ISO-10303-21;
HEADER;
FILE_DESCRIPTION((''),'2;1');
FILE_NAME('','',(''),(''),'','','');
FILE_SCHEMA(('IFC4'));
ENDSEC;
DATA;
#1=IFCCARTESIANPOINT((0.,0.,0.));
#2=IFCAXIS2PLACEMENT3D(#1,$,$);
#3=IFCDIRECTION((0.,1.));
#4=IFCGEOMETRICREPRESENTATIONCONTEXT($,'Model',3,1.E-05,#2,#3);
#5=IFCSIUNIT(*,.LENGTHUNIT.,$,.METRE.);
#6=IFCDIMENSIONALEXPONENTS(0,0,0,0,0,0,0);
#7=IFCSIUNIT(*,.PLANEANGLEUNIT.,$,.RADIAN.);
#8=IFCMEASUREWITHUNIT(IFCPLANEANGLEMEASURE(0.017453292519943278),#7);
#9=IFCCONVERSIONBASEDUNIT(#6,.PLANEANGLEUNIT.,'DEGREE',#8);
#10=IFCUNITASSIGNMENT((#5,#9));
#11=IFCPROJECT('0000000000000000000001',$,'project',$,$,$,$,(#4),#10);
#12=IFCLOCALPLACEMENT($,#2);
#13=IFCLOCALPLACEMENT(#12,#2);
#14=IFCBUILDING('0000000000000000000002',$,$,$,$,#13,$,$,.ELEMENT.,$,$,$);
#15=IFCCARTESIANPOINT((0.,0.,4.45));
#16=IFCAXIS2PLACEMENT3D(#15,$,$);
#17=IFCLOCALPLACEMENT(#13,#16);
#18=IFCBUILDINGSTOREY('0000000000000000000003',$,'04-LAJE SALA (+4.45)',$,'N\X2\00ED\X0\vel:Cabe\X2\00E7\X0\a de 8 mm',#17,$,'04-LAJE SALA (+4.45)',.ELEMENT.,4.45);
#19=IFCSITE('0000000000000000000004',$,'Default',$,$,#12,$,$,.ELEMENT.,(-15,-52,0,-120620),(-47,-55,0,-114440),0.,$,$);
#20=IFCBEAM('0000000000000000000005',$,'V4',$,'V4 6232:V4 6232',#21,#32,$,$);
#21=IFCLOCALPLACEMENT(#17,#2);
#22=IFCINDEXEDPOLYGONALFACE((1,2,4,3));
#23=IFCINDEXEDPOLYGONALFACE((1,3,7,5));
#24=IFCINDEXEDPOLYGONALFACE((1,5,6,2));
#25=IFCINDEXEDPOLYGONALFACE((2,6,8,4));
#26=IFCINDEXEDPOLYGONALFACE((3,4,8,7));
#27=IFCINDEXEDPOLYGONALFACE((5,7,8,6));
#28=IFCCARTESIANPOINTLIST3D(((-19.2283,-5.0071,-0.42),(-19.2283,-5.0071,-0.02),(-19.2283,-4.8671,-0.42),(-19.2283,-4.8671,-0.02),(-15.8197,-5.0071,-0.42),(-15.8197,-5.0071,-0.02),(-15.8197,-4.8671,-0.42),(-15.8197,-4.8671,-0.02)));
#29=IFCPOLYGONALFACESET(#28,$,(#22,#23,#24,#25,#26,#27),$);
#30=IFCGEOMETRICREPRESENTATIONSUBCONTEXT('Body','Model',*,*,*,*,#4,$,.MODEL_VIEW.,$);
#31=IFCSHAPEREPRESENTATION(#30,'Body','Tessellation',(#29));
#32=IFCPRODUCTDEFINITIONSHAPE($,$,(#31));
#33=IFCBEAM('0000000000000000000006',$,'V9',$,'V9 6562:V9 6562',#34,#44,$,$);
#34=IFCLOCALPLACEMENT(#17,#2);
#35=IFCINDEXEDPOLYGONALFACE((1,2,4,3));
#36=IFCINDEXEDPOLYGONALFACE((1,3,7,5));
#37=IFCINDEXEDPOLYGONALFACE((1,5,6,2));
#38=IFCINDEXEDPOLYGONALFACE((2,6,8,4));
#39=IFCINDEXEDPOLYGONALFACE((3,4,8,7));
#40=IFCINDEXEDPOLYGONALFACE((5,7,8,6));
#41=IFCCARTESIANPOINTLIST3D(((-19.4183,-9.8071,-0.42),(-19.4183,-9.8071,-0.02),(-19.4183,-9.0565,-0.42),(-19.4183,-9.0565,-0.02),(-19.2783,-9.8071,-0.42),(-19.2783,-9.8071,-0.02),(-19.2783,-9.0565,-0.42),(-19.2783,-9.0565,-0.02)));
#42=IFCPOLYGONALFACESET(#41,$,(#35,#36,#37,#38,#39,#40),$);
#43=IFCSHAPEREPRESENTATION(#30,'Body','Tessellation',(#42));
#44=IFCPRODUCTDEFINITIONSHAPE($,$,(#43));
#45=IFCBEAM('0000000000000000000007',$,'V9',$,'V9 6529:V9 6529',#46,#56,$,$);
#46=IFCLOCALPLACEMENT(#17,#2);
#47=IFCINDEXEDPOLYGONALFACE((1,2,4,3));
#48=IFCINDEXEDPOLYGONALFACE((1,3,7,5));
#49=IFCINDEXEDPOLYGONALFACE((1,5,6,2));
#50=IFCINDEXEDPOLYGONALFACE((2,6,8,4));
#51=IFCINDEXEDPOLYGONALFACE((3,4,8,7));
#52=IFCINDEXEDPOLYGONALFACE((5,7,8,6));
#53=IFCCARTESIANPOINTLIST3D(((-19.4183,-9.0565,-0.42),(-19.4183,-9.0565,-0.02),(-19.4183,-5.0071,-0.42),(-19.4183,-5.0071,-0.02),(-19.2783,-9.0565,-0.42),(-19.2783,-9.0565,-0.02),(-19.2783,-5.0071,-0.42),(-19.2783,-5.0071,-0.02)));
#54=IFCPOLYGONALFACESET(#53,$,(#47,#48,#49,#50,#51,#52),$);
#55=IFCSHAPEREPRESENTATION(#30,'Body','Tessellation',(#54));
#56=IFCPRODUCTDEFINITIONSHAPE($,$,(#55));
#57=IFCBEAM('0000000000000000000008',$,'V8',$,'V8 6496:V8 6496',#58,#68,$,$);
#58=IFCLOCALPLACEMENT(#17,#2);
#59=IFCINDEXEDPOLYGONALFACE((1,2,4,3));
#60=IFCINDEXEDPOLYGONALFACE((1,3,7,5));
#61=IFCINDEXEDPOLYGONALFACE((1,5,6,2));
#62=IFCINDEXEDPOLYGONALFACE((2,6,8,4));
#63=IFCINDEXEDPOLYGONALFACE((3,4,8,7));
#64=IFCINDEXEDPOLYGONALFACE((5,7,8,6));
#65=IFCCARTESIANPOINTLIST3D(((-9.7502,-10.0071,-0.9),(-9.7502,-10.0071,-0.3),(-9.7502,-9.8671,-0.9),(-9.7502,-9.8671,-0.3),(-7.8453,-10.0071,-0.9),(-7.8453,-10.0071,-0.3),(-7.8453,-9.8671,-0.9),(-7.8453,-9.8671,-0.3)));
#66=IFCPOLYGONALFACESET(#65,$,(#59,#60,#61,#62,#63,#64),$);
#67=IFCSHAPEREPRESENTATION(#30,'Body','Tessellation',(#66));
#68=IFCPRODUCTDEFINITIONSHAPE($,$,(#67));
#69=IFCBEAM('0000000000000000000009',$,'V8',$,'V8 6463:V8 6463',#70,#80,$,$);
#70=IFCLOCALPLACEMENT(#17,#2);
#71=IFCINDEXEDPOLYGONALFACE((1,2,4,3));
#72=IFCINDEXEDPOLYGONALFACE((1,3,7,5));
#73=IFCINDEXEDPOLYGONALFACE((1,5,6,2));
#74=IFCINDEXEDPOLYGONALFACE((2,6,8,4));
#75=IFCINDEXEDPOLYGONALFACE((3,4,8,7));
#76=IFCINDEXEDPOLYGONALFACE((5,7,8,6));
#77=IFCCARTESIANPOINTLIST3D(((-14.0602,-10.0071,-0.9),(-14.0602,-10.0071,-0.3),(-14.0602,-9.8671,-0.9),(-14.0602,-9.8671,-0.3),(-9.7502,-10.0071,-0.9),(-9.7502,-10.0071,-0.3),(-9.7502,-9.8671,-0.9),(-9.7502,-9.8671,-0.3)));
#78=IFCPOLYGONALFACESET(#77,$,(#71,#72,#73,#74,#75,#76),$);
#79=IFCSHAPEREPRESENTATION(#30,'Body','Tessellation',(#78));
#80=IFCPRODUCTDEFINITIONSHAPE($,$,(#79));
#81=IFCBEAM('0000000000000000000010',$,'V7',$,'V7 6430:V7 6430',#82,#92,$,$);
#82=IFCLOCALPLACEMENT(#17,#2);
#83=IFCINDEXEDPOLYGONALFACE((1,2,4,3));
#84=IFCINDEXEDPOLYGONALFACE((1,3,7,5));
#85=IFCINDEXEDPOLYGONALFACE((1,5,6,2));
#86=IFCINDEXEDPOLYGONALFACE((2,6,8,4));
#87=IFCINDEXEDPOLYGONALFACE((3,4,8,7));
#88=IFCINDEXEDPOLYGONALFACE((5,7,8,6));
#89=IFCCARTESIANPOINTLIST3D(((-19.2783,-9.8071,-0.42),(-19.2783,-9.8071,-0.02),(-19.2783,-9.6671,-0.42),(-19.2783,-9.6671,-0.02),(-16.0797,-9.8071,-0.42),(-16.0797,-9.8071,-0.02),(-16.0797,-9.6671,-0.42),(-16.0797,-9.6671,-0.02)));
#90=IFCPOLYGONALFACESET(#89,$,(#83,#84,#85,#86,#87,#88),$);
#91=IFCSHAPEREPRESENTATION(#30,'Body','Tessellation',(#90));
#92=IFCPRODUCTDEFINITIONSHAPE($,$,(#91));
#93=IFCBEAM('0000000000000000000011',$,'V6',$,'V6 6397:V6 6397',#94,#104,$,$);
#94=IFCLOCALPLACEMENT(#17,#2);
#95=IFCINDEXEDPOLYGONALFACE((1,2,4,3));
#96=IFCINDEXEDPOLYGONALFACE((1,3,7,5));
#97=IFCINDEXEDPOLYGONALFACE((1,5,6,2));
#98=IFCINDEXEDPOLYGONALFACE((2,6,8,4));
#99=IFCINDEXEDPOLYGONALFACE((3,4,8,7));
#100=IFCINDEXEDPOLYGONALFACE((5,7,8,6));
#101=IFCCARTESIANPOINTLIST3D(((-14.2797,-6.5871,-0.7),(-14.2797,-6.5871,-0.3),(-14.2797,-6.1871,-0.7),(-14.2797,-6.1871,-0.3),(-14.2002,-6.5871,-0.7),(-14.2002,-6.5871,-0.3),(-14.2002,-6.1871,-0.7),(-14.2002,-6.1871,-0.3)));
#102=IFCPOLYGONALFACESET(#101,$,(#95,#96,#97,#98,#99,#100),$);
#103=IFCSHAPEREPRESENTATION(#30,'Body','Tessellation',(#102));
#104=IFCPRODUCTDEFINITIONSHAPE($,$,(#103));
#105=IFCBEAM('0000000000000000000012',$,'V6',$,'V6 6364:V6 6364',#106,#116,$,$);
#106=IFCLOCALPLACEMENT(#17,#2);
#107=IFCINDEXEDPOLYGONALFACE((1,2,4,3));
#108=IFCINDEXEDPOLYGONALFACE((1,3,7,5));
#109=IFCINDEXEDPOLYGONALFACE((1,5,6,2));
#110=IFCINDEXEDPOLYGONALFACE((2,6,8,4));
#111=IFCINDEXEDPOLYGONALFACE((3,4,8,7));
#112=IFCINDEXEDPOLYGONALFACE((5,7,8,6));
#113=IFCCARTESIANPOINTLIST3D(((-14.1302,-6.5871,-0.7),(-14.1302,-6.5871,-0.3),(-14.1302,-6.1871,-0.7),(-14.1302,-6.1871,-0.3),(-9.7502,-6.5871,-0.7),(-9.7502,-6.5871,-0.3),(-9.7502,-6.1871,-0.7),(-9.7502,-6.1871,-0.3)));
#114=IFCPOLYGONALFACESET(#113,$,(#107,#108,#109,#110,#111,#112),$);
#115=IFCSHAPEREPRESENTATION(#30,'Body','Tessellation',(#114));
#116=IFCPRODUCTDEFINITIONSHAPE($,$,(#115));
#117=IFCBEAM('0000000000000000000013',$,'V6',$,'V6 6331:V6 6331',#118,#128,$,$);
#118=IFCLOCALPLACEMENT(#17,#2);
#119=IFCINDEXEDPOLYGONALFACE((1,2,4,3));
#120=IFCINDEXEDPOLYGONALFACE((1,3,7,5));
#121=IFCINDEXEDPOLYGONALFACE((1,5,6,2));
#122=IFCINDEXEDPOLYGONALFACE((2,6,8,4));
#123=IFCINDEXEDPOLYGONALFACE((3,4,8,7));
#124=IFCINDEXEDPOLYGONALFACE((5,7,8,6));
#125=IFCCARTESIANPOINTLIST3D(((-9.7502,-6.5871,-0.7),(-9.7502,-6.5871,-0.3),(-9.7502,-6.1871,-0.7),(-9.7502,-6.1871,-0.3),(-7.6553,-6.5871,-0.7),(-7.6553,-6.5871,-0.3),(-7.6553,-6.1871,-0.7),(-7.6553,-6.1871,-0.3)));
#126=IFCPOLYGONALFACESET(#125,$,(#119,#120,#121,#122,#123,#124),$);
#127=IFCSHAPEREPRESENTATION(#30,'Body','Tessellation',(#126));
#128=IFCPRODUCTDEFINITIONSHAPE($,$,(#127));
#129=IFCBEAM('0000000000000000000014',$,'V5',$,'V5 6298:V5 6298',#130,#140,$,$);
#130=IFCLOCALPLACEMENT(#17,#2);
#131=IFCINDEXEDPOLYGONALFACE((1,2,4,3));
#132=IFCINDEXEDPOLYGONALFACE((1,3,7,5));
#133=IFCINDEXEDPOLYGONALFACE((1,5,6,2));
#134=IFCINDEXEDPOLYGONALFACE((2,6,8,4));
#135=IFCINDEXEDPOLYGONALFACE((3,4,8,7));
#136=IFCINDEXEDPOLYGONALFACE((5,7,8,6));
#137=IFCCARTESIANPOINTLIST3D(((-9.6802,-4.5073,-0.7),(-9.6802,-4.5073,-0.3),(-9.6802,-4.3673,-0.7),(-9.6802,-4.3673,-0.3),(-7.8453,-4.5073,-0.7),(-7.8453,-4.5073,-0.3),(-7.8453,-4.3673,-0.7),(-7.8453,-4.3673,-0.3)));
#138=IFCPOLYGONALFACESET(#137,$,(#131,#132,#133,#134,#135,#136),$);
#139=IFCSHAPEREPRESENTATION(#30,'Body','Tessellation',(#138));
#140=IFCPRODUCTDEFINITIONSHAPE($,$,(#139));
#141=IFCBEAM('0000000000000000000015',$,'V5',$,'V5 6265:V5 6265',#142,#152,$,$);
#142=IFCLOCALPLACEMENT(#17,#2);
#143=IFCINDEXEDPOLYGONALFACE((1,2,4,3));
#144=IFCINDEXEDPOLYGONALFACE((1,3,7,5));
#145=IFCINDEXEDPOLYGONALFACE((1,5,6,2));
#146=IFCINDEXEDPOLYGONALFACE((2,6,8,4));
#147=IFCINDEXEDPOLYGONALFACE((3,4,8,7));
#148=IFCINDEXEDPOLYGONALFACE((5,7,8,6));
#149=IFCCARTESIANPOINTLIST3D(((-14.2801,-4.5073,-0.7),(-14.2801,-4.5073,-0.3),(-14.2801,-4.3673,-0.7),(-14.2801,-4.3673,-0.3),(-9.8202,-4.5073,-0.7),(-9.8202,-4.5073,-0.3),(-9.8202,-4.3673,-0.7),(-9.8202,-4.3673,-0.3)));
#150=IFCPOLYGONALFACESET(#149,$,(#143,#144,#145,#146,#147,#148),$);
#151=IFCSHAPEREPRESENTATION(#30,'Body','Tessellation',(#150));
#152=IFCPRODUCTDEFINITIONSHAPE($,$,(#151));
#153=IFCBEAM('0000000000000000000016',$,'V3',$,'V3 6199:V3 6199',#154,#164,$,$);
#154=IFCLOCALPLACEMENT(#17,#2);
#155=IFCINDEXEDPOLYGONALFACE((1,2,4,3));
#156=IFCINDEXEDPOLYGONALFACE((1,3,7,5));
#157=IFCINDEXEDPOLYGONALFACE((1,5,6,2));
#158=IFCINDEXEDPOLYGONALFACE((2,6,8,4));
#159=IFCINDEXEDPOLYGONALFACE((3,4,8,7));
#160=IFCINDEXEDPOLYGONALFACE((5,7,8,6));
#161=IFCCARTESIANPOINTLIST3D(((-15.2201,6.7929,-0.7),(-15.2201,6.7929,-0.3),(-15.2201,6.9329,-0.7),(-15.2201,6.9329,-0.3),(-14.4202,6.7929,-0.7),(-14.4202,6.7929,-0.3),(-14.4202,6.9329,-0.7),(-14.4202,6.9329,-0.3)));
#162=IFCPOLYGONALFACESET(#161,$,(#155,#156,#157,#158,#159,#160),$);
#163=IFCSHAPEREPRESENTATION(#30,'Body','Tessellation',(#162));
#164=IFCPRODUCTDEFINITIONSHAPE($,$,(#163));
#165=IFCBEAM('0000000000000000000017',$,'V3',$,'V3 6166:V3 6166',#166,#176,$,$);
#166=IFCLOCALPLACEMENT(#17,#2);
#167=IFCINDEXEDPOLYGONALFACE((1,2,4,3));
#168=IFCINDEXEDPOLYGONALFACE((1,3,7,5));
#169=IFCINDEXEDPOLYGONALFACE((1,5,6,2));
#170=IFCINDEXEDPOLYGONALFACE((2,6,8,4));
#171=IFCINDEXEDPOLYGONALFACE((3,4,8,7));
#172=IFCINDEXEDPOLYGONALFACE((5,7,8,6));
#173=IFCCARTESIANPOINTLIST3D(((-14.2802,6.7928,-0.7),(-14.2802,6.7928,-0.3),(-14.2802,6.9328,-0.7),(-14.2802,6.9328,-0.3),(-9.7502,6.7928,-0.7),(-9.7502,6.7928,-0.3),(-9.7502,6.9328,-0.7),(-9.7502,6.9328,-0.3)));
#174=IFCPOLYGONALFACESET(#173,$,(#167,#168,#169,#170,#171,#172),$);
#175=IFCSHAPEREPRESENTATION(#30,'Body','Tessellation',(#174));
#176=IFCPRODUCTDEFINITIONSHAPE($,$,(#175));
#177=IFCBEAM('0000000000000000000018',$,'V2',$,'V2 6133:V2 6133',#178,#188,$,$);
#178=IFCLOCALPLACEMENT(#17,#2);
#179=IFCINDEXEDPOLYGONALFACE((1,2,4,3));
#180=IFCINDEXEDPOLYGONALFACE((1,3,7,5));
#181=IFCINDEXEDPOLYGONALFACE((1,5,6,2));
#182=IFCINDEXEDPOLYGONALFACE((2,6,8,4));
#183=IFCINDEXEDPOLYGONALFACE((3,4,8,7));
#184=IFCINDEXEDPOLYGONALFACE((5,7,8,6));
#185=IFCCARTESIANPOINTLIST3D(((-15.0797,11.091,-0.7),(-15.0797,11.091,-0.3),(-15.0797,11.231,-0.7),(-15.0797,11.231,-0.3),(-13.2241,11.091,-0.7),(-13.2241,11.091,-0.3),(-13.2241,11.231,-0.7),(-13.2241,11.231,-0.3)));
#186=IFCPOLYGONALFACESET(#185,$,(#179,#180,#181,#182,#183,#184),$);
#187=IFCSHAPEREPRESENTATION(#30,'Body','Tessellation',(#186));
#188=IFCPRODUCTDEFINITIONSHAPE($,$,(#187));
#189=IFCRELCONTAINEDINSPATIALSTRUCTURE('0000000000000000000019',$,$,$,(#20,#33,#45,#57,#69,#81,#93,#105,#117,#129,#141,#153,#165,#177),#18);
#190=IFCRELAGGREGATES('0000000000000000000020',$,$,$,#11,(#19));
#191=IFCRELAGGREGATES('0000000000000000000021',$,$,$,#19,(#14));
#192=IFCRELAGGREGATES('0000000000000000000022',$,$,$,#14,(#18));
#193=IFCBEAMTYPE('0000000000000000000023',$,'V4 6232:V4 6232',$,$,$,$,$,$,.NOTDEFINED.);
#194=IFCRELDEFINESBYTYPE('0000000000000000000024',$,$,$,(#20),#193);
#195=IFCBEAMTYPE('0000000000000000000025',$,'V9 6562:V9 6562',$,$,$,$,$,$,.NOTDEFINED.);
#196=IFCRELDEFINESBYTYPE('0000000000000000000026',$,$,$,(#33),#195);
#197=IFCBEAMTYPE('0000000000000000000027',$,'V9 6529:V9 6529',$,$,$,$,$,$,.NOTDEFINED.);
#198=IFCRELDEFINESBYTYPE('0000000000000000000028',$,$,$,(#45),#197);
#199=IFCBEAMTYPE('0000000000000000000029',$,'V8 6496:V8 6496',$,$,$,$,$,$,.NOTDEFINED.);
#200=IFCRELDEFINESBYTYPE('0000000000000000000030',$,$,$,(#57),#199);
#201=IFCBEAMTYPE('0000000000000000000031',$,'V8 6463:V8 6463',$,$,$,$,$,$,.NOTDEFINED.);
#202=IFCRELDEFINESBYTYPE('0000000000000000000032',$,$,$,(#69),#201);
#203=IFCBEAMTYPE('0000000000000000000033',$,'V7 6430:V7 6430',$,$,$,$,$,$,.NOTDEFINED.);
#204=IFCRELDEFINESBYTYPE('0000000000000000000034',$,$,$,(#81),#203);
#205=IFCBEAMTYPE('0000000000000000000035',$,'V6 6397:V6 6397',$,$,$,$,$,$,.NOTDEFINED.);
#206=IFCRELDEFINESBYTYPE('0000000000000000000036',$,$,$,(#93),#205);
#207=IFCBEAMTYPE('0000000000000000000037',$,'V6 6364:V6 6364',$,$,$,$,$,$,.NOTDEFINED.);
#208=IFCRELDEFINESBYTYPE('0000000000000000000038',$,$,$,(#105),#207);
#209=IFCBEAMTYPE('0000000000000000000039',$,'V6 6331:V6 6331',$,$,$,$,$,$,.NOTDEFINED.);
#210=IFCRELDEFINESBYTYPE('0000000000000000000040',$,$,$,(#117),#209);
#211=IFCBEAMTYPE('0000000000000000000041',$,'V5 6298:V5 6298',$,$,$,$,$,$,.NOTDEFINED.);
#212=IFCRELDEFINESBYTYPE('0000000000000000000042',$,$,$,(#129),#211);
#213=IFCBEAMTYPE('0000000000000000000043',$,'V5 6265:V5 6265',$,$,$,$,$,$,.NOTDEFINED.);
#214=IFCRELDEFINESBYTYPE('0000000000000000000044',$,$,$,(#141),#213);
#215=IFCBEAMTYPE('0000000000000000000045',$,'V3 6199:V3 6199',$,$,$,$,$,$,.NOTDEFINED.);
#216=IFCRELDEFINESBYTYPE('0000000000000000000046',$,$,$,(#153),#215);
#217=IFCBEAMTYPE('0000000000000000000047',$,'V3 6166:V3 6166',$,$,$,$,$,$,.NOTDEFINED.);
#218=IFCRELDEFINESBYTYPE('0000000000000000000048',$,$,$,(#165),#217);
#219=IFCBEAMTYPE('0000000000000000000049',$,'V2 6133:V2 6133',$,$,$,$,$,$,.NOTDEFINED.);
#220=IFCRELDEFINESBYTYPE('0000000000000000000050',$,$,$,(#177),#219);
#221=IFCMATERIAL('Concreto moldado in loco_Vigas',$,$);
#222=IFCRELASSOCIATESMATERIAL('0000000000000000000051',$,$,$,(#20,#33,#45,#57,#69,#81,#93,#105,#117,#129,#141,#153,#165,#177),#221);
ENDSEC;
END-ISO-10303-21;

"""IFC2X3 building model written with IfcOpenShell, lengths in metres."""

from ifc_helpers import new_model, entity, si_unit, converted_unit, direction, frame, frame_2d, origin, origin_2d_with_axis, place, context, subcontext, project, spatial, rectangle, extrude, material, type_object, element, save


model = new_model("IFC2X3")

# Units and contexts
model_context = context("Model", 3, precision=1e-05, world=origin(), true_north=direction((0.0, 1.0)))
body_context = subcontext(model_context, "Body", "Model", "MODEL_VIEW")
ifc_project = project(units=[si_unit("LENGTHUNIT", "METRE"), converted_unit("PLANEANGLEUNIT", "DEGREE", entity("IfcPlaneAngleMeasure", 0.017453292519943278), si_unit("PLANEANGLEUNIT", "RADIAN"), dimensions=[0, 0, 0, 0, 0, 0, 0])], contexts=[model_context])

# Site, building, storey
site_placement = place(None, origin())
site = spatial("IfcSite", under=ifc_project, at=site_placement, Name="Default", CompositionType="ELEMENT", RefLatitude=(-15, -52, 0, -120620), RefLongitude=(-47, -55, 0, -114440), RefElevation=0.0)
building_placement = place(site_placement, origin())
building = spatial("IfcBuilding", under=site, at=building_placement, CompositionType="ELEMENT")
storey_placement = place(building_placement, frame((0.0, 0.0, 4.45)))
storey = spatial("IfcBuildingStorey", under=building, at=storey_placement, Name="04-LAJE SALA (+4.45)", ObjectType="Nível:Cabeça de 8 mm", LongName="04-LAJE SALA (+4.45)", CompositionType="ELEMENT", Elevation=4.45)

# Beams
ifc_material_1 = material(Name="Concreto moldado in loco_Vigas")
beam_type_1 = type_object("IfcBeamType", Name="V4 6232:V4 6232", PredefinedType="NOTDEFINED")
beam_1_placement = place(storey_placement, origin())
element("IfcBeam", 1, at=beam_1_placement, inside=storey, type_object=beam_type_1, material=ifc_material_1, Name="V4", ObjectType="V4 6232:V4 6232", context=body_context, shape_type="SweptSolid", body=[
    extrude(rectangle(XDim=0.4, YDim=0.14, at=frame_2d((0.0, 0.0), x_axis=(1.0, 0.0))), frame((-19.2283, -4.9371, -0.22), z_axis=(1.0, 0.0, 0.0), x_axis=(0.0, 0.0, -1.0)), (0.0, 0.0, 1.0), 3.4086),
])
beam_type_2 = type_object("IfcBeamType", Name="V9 6562:V9 6562", PredefinedType="NOTDEFINED")
beam_2_placement = place(storey_placement, origin())
element("IfcBeam", 2, at=beam_2_placement, inside=storey, type_object=beam_type_2, material=ifc_material_1, Name="V9", ObjectType="V9 6562:V9 6562", context=body_context, shape_type="SweptSolid", body=[
    extrude(rectangle(XDim=0.4, YDim=0.7506, at=frame_2d((0.0, 0.0), x_axis=(0.0, 1.0))), frame((-19.4183, -9.4318, -0.22), z_axis=(1.0, 0.0, 0.0), x_axis=(0.0, -1.0, 0.0)), (0.0, 0.0, 1.0), 0.14),
])
beam_type_3 = type_object("IfcBeamType", Name="V9 6529:V9 6529", PredefinedType="NOTDEFINED")
beam_3_placement = place(storey_placement, origin())
element("IfcBeam", 3, at=beam_3_placement, inside=storey, type_object=beam_type_3, material=ifc_material_1, Name="V9", ObjectType="V9 6529:V9 6529", context=body_context, shape_type="SweptSolid", body=[
    extrude(rectangle(XDim=0.4, YDim=4.0494, at=frame_2d((0.0, 0.0), x_axis=(0.0, 1.0))), frame((-19.4183, -7.0318, -0.22), z_axis=(1.0, 0.0, 0.0), x_axis=(0.0, -1.0, 0.0)), (0.0, 0.0, 1.0), 0.14),
])
beam_type_4 = type_object("IfcBeamType", Name="V8 6496:V8 6496", PredefinedType="NOTDEFINED")
beam_4_placement = place(storey_placement, origin())
element("IfcBeam", 4, at=beam_4_placement, inside=storey, type_object=beam_type_4, material=ifc_material_1, Name="V8", ObjectType="V8 6496:V8 6496", context=body_context, shape_type="SweptSolid", body=[
    extrude(rectangle(XDim=0.6, YDim=0.14, at=frame_2d((0.0, 0.0), x_axis=(1.0, 0.0))), frame((-9.7502, -9.9371, -0.6), z_axis=(1.0, 0.0, 0.0), x_axis=(0.0, 0.0, -1.0)), (0.0, 0.0, 1.0), 1.9049),
])
beam_type_5 = type_object("IfcBeamType", Name="V8 6463:V8 6463", PredefinedType="NOTDEFINED")
beam_5_placement = place(storey_placement, origin())
element("IfcBeam", 5, at=beam_5_placement, inside=storey, type_object=beam_type_5, material=ifc_material_1, Name="V8", ObjectType="V8 6463:V8 6463", context=body_context, shape_type="SweptSolid", body=[
    extrude(rectangle(XDim=0.6, YDim=0.14, at=frame_2d((0.0, 0.0), x_axis=(1.0, 0.0))), frame((-14.0602, -9.9371, -0.6), z_axis=(1.0, 0.0, 0.0), x_axis=(0.0, 0.0, -1.0)), (0.0, 0.0, 1.0), 4.31),
])
beam_type_6 = type_object("IfcBeamType", Name="V7 6430:V7 6430", PredefinedType="NOTDEFINED")
beam_6_placement = place(storey_placement, origin())
element("IfcBeam", 6, at=beam_6_placement, inside=storey, type_object=beam_type_6, material=ifc_material_1, Name="V7", ObjectType="V7 6430:V7 6430", context=body_context, shape_type="SweptSolid", body=[
    extrude(rectangle(XDim=0.4, YDim=0.14, at=frame_2d((0.0, 0.0), x_axis=(1.0, 0.0))), frame((-19.2783, -9.7371, -0.22), z_axis=(1.0, 0.0, 0.0), x_axis=(0.0, 0.0, -1.0)), (0.0, 0.0, 1.0), 3.1986),
])
beam_type_7 = type_object("IfcBeamType", Name="V6 6397:V6 6397", PredefinedType="NOTDEFINED")
beam_7_placement = place(storey_placement, origin())
element("IfcBeam", 7, at=beam_7_placement, inside=storey, type_object=beam_type_7, material=ifc_material_1, Name="V6", ObjectType="V6 6397:V6 6397", context=body_context, shape_type="SweptSolid", body=[
    extrude(rectangle(XDim=0.4, YDim=0.4, at=origin_2d_with_axis()), frame((-14.2797, -6.3871, -0.5), z_axis=(1.0, 0.0, 0.0), x_axis=(0.0, 0.0, -1.0)), (0.0, 0.0, 1.0), 0.0795),
])
beam_type_8 = type_object("IfcBeamType", Name="V6 6364:V6 6364", PredefinedType="NOTDEFINED")
beam_8_placement = place(storey_placement, origin())
element("IfcBeam", 8, at=beam_8_placement, inside=storey, type_object=beam_type_8, material=ifc_material_1, Name="V6", ObjectType="V6 6364:V6 6364", context=body_context, shape_type="SweptSolid", body=[
    extrude(rectangle(XDim=0.4, YDim=0.4, at=origin_2d_with_axis()), frame((-14.1302, -6.3871, -0.5), z_axis=(1.0, 0.0, 0.0), x_axis=(0.0, 0.0, -1.0)), (0.0, 0.0, 1.0), 4.38),
])
beam_type_9 = type_object("IfcBeamType", Name="V6 6331:V6 6331", PredefinedType="NOTDEFINED")
beam_9_placement = place(storey_placement, origin())
element("IfcBeam", 9, at=beam_9_placement, inside=storey, type_object=beam_type_9, material=ifc_material_1, Name="V6", ObjectType="V6 6331:V6 6331", context=body_context, shape_type="SweptSolid", body=[
    extrude(rectangle(XDim=0.4, YDim=0.4, at=origin_2d_with_axis()), frame((-9.7502, -6.3871, -0.5), z_axis=(1.0, 0.0, 0.0), x_axis=(0.0, 0.0, -1.0)), (0.0, 0.0, 1.0), 2.0949),
])
beam_type_10 = type_object("IfcBeamType", Name="V5 6298:V5 6298", PredefinedType="NOTDEFINED")
beam_10_placement = place(storey_placement, origin())
element("IfcBeam", 10, at=beam_10_placement, inside=storey, type_object=beam_type_10, material=ifc_material_1, Name="V5", ObjectType="V5 6298:V5 6298", context=body_context, shape_type="SweptSolid", body=[
    extrude(rectangle(XDim=0.4, YDim=0.14, at=frame_2d((0.0, 0.0), x_axis=(1.0, 0.0))), frame((-9.6802, -4.4373, -0.5), z_axis=(1.0, 0.0, 0.0), x_axis=(0.0, 0.0, -1.0)), (0.0, 0.0, 1.0), 1.8349),
])
beam_type_11 = type_object("IfcBeamType", Name="V5 6265:V5 6265", PredefinedType="NOTDEFINED")
beam_11_placement = place(storey_placement, origin())
element("IfcBeam", 11, at=beam_11_placement, inside=storey, type_object=beam_type_11, material=ifc_material_1, Name="V5", ObjectType="V5 6265:V5 6265", context=body_context, shape_type="SweptSolid", body=[
    extrude(rectangle(XDim=0.4, YDim=0.14, at=frame_2d((0.0, 0.0), x_axis=(1.0, 0.0))), frame((-14.2801, -4.4373, -0.5), z_axis=(1.0, 0.0, 0.0), x_axis=(0.0, 0.0, -1.0)), (0.0, 0.0, 1.0), 4.4599),
])
beam_type_12 = type_object("IfcBeamType", Name="V3 6199:V3 6199", PredefinedType="NOTDEFINED")
beam_12_placement = place(storey_placement, origin())
element("IfcBeam", 12, at=beam_12_placement, inside=storey, type_object=beam_type_12, material=ifc_material_1, Name="V3", ObjectType="V3 6199:V3 6199", context=body_context, shape_type="SweptSolid", body=[
    extrude(rectangle(XDim=0.4, YDim=0.14, at=frame_2d((0.0, 0.0), x_axis=(1.0, 0.0))), frame((-15.2201, 6.8629, -0.5), z_axis=(1.0, 0.0, 0.0), x_axis=(0.0, 0.0, -1.0)), (0.0, 0.0, 1.0), 0.7999),
])
beam_type_13 = type_object("IfcBeamType", Name="V3 6166:V3 6166", PredefinedType="NOTDEFINED")
beam_13_placement = place(storey_placement, origin())
element("IfcBeam", 13, at=beam_13_placement, inside=storey, type_object=beam_type_13, material=ifc_material_1, Name="V3", ObjectType="V3 6166:V3 6166", context=body_context, shape_type="SweptSolid", body=[
    extrude(rectangle(XDim=0.4, YDim=0.14, at=frame_2d((0.0, 0.0), x_axis=(1.0, 0.0))), frame((-14.2802, 6.8628, -0.5), z_axis=(1.0, 0.0, 0.0), x_axis=(0.0, 0.0, -1.0)), (0.0, 0.0, 1.0), 4.53),
])
beam_type_14 = type_object("IfcBeamType", Name="V2 6133:V2 6133", PredefinedType="NOTDEFINED")
beam_14_placement = place(storey_placement, origin())
element("IfcBeam", 14, at=beam_14_placement, inside=storey, type_object=beam_type_14, material=ifc_material_1, Name="V2", ObjectType="V2 6133:V2 6133", context=body_context, shape_type="SweptSolid", body=[
    extrude(rectangle(XDim=0.4, YDim=0.14, at=frame_2d((0.0, 0.0), x_axis=(1.0, 0.0))), frame((-15.0797, 11.161, -0.5), z_axis=(1.0, 0.0, 0.0), x_axis=(0.0, 0.0, -1.0)), (0.0, 0.0, 1.0), 1.8556),
])

save(model, "model.ifc")
